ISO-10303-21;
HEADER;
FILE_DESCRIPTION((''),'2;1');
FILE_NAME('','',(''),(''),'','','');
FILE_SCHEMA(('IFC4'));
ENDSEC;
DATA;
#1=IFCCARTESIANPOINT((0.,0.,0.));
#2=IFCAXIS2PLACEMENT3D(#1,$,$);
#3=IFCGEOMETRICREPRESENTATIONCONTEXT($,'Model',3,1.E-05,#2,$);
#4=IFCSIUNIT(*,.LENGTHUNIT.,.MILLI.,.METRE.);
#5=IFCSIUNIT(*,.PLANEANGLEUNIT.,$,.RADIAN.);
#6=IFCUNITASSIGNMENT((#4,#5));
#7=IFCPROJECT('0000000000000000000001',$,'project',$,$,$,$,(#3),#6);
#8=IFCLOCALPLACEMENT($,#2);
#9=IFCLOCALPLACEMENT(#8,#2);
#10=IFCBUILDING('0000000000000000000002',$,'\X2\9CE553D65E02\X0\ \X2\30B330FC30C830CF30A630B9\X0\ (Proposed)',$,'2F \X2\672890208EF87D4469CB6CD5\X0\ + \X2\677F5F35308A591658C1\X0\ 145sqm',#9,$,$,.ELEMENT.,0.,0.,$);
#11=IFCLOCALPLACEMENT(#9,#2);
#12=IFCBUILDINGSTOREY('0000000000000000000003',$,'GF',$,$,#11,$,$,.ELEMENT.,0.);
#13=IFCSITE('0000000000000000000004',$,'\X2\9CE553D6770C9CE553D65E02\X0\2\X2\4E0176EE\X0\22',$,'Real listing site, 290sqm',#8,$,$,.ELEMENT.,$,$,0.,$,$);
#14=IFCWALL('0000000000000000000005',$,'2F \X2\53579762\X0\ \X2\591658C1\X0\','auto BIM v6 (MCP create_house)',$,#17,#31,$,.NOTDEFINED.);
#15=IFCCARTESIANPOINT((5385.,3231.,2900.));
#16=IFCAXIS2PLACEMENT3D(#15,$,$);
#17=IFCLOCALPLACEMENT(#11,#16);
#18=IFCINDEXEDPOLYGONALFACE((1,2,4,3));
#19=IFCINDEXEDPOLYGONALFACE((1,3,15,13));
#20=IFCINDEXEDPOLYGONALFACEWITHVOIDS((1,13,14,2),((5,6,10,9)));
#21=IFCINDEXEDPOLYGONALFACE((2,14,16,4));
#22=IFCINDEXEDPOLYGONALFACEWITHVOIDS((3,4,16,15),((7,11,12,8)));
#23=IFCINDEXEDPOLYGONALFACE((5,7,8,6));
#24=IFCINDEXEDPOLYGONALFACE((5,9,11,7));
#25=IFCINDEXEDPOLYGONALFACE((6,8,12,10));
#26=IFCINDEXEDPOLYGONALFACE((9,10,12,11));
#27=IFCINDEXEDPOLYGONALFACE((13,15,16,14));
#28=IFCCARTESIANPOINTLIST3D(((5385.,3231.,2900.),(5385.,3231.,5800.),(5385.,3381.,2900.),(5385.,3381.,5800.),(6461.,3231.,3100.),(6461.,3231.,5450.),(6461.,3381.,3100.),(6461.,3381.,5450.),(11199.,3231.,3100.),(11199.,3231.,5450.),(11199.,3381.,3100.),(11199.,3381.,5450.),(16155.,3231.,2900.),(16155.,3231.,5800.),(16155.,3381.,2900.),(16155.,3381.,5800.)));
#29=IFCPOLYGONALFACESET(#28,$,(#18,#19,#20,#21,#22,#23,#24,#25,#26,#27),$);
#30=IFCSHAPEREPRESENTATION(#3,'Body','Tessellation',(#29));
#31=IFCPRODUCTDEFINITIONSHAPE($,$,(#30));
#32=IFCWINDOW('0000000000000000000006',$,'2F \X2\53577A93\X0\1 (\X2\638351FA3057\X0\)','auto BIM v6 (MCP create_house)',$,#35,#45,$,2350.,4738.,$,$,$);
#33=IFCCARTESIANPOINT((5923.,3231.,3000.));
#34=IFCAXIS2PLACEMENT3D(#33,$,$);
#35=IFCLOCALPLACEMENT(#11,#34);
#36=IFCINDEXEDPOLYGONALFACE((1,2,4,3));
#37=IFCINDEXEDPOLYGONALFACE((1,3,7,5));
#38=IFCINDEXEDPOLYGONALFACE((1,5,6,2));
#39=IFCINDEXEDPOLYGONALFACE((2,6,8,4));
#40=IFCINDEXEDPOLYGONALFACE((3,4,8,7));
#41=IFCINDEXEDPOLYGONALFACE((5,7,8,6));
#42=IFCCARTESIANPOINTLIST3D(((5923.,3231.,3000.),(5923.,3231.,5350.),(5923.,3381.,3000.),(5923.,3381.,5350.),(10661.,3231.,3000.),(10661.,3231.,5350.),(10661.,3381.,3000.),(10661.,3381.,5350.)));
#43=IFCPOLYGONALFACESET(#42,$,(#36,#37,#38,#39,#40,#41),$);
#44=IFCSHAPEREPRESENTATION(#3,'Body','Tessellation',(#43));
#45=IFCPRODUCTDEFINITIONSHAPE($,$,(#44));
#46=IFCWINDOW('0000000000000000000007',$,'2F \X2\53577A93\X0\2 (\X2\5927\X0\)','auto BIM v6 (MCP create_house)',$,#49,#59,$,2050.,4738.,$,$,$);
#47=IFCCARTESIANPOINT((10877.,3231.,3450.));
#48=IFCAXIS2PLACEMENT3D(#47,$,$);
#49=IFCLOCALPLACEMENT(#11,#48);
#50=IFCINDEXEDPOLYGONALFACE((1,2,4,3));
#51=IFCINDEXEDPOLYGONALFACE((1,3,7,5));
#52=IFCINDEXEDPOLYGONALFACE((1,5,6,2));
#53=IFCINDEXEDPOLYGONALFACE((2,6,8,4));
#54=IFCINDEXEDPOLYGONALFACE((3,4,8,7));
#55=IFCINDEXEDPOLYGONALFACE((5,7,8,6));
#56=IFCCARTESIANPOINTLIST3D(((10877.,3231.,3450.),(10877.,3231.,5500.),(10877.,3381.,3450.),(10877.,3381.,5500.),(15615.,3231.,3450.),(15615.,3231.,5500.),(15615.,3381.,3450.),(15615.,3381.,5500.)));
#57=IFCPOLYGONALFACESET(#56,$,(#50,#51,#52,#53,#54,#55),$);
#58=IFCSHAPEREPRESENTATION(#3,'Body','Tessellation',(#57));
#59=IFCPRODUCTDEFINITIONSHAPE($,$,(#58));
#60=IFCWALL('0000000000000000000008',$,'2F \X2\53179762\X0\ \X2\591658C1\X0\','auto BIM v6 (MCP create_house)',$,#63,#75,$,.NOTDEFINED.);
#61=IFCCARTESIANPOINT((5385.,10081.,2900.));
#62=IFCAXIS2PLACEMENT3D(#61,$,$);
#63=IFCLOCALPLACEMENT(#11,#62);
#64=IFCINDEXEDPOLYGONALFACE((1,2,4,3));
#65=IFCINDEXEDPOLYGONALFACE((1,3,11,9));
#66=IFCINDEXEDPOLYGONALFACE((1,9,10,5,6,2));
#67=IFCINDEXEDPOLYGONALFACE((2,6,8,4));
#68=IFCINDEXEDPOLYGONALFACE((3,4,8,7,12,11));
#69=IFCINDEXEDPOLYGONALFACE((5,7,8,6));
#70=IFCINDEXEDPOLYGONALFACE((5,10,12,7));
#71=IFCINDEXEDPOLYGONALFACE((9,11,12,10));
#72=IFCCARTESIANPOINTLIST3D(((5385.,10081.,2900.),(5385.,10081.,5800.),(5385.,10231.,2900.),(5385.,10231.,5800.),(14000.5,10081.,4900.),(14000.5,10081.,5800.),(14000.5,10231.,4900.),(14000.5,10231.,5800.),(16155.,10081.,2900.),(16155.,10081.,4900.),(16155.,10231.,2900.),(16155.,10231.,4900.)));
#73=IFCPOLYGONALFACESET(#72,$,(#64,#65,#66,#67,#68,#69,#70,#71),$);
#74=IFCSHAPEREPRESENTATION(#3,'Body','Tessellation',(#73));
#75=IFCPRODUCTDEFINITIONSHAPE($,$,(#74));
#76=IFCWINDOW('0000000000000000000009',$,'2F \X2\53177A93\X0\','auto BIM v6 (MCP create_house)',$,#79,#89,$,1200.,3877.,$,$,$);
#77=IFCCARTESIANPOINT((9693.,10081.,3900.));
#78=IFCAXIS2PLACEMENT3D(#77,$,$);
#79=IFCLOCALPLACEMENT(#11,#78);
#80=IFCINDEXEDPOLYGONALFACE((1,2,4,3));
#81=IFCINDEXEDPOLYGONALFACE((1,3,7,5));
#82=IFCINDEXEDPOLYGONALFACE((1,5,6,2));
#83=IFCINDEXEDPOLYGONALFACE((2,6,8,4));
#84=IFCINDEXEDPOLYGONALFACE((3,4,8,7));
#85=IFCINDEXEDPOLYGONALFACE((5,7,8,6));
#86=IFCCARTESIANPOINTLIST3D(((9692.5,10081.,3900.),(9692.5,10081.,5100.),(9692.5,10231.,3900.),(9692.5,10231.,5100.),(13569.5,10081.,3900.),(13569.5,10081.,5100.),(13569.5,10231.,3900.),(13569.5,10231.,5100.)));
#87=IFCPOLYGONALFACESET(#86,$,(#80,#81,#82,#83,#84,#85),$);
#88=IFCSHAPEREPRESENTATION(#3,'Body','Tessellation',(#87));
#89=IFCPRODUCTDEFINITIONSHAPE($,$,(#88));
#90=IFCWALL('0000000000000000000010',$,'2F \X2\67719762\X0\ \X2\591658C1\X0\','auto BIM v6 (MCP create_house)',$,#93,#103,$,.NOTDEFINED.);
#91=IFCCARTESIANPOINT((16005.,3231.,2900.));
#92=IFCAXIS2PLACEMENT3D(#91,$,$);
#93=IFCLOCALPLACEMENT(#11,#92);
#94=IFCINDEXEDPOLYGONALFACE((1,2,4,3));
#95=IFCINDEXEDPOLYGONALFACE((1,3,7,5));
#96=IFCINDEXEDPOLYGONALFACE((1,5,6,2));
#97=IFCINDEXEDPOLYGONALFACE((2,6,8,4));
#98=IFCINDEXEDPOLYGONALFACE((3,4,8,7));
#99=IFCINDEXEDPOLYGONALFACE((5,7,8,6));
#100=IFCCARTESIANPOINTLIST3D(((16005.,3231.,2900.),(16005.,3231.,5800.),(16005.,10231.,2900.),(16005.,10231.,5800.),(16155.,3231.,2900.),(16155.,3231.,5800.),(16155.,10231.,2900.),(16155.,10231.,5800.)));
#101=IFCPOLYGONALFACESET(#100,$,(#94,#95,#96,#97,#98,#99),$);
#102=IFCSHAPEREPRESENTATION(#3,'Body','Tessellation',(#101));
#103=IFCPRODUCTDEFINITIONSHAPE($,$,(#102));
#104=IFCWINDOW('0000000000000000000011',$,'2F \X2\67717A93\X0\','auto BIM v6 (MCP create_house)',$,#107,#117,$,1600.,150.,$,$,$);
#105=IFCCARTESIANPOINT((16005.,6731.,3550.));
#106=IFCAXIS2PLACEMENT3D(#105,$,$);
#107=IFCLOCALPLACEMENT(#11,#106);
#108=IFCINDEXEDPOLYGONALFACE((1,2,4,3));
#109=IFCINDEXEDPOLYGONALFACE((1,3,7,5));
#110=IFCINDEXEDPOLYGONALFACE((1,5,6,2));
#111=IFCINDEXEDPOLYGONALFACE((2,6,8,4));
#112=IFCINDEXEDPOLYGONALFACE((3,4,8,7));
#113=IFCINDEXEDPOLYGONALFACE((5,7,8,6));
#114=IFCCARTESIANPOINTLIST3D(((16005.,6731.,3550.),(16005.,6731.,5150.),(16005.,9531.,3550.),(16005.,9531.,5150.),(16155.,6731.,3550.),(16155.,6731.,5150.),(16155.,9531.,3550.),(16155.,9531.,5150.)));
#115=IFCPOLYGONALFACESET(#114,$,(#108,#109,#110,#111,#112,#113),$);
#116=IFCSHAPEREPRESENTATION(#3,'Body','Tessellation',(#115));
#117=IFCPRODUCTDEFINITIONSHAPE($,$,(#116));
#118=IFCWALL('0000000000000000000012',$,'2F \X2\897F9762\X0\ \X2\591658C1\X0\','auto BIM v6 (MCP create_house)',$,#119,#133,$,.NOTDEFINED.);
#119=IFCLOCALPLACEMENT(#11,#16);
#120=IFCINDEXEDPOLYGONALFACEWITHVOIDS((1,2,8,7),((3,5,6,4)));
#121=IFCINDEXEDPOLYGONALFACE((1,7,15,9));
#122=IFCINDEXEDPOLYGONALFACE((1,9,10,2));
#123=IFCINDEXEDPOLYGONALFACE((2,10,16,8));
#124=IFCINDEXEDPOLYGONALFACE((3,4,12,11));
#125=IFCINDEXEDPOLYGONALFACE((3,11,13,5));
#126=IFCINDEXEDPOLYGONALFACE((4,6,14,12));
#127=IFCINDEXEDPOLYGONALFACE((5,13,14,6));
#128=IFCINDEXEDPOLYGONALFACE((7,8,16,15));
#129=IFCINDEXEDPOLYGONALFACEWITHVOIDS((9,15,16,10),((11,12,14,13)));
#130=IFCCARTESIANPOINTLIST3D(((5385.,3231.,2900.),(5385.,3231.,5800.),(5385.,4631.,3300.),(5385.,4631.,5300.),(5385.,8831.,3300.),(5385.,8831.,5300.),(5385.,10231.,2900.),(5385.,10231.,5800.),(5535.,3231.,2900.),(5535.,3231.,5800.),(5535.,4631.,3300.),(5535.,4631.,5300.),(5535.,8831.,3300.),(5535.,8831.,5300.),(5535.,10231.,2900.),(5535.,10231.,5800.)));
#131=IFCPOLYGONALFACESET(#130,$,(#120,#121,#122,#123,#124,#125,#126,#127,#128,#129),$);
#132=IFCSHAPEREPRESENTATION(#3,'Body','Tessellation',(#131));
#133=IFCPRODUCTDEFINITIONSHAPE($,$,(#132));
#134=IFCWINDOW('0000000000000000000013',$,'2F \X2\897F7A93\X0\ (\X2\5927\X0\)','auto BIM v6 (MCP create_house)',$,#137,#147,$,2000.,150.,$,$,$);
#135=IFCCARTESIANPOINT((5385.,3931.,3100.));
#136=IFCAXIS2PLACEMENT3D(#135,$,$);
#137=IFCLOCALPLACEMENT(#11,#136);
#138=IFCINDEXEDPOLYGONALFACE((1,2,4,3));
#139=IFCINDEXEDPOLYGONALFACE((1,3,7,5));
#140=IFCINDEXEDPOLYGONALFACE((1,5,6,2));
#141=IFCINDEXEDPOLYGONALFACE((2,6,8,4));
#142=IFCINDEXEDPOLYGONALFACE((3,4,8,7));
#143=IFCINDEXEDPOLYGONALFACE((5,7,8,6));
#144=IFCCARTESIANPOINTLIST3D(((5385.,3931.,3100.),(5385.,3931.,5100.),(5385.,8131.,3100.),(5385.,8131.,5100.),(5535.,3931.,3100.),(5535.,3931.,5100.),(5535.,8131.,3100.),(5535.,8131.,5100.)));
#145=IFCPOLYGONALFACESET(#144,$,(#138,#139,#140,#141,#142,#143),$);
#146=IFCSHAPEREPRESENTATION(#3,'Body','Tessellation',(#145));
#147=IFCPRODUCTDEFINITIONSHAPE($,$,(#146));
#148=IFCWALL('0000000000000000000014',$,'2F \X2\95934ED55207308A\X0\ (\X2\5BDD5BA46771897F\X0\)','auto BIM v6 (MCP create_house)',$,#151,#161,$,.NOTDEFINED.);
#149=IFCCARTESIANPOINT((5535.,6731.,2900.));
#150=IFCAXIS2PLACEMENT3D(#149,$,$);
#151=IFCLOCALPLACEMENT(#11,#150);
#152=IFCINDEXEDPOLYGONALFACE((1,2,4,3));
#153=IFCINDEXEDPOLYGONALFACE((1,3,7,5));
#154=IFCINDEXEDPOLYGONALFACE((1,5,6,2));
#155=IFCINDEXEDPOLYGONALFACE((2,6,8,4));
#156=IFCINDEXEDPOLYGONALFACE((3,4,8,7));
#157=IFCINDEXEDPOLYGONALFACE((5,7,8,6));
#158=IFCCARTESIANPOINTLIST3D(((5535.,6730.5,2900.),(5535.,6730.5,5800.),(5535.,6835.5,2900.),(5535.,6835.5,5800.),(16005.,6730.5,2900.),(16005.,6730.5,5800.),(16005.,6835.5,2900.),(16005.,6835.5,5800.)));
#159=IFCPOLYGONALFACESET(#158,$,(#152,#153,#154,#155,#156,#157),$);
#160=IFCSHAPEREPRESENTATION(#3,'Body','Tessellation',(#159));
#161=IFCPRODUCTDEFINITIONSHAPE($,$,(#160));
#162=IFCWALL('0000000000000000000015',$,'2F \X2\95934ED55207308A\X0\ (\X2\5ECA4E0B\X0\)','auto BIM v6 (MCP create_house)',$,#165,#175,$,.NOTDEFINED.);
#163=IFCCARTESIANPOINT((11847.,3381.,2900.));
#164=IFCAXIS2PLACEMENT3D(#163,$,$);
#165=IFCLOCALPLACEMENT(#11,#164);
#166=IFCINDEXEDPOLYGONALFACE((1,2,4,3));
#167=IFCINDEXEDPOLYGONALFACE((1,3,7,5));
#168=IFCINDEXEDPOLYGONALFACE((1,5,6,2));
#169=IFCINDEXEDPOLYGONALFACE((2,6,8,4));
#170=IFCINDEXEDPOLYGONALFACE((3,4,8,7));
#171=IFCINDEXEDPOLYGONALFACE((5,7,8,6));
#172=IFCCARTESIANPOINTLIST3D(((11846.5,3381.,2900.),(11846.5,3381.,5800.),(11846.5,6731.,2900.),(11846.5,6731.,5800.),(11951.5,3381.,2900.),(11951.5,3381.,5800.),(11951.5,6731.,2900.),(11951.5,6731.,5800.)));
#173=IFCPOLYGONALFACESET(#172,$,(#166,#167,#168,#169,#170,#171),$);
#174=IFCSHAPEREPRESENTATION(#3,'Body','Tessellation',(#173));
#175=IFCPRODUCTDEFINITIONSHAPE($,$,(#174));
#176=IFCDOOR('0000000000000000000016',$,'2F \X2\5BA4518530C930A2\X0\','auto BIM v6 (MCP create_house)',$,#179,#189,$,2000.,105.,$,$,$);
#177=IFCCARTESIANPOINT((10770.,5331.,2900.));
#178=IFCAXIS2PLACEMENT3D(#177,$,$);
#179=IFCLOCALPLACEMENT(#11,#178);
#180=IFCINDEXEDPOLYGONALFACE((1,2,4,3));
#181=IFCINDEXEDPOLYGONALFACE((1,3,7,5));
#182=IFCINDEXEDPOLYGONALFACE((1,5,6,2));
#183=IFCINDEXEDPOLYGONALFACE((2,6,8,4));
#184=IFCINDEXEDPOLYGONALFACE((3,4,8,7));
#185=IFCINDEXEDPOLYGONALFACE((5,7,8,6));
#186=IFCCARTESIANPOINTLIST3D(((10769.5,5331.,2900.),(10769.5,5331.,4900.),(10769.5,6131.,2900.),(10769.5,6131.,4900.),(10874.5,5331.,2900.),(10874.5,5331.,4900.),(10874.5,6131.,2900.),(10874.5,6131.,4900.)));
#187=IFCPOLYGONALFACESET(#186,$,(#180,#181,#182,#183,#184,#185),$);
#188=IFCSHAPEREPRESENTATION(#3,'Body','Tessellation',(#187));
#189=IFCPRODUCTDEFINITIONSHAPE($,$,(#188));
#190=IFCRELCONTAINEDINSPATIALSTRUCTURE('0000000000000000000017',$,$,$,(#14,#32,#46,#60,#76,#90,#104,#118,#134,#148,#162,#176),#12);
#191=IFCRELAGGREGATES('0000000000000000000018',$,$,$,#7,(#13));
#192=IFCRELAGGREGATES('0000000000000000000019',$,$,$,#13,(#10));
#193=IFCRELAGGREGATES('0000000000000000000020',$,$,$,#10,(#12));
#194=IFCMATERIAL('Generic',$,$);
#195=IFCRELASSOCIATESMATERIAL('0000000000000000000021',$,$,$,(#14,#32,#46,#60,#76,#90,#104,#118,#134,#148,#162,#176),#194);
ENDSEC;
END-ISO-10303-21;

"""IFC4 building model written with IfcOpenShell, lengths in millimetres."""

from ifc_helpers import new_model, si_unit, frame, frame_2d, origin, place, context, project, spatial, rectangle, extrude, material, element, fill, save


model = new_model("IFC4")

# Units and contexts
model_context = context("Model", 3, precision=1e-05, world=origin())
ifc_project = project(units=[si_unit("LENGTHUNIT", "METRE", prefix="MILLI"), si_unit("PLANEANGLEUNIT", "RADIAN")], contexts=[model_context])

# Site, building, storey
site_placement = place(None, origin())
site = spatial("IfcSite", under=ifc_project, at=site_placement, Name="鳥取県鳥取市2丁目22", ObjectType="Real listing site, 290sqm", CompositionType="ELEMENT", RefElevation=0.0)
building_placement = place(site_placement, origin())
building = spatial("IfcBuilding", under=site, at=building_placement, Name="鳥取市 コートハウス (Proposed)", ObjectType="2F 木造軸組構法 + 板張り外壁 145sqm", CompositionType="ELEMENT", ElevationOfRefHeight=0.0, ElevationOfTerrain=0.0)
storey_placement = place(building_placement, origin())
storey = spatial("IfcBuildingStorey", under=building, at=storey_placement, Name="GF", CompositionType="ELEMENT", Elevation=0.0)

# Shared definitions
ifc_material = material(Name="Generic")

# Wall, openings, windows
wall_1_placement = place(storey_placement, frame((5385.0, 3231.0, 2900.0)))
wall_1 = element("IfcWall", 1, at=wall_1_placement, inside=storey, material=ifc_material, Name="2F 南面 外壁", Description="auto BIM v6 (MCP create_house)", PredefinedType="NOTDEFINED", context=model_context, shape_type="SweptSolid", body=[
    extrude(rectangle(XDim=10770.0, YDim=150.0, at=frame_2d((5385.0, 75.0))), frame((5385.0, 3231.0, 2900.0)), (0.0, 0.0, 1.0), 2900.0),
])
opening_1_placement = place(storey_placement, frame((5923.0, 3231.0, 3000.0)))
opening_1 = element("IfcOpeningElement", 2, at=opening_1_placement, cuts=wall_1, PredefinedType="NOTDEFINED", context=model_context, shape_type="SweptSolid", body=[
    extrude(rectangle(XDim=4738.0, YDim=150.0, at=frame_2d((2369.0, 75.0))), frame((5923.0, 3231.0, 3000.0)), (0.0, 0.0, 1.0), 2350.0),
])
opening_2_placement = place(storey_placement, frame((10877.0, 3231.0, 3450.0)))
opening_2 = element("IfcOpeningElement", 3, at=opening_2_placement, cuts=wall_1, PredefinedType="NOTDEFINED", context=model_context, shape_type="SweptSolid", body=[
    extrude(rectangle(XDim=4738.0, YDim=150.0, at=frame_2d((2369.0, 75.0))), frame((10877.0, 3231.0, 3450.0)), (0.0, 0.0, 1.0), 2050.0),
])
window_1_placement = place(storey_placement, frame((5923.0, 3231.0, 3000.0)))
window_1 = element("IfcWindow", 4, at=window_1_placement, inside=storey, material=ifc_material, Name="2F 南窓1 (掃出し)", Description="auto BIM v6 (MCP create_house)", OverallHeight=2350.0, OverallWidth=4738.0, context=model_context, shape_type="SweptSolid", body=[
    extrude(rectangle(XDim=4738.0, YDim=150.0, at=frame_2d((2369.0, 75.0))), frame((5923.0, 3231.0, 3000.0)), (0.0, 0.0, 1.0), 2350.0),
])
fill(opening_1, window_1)
window_2_placement = place(storey_placement, frame((10877.0, 3231.0, 3450.0)))
window_2 = element("IfcWindow", 5, at=window_2_placement, inside=storey, material=ifc_material, Name="2F 南窓2 (大)", Description="auto BIM v6 (MCP create_house)", OverallHeight=2050.0, OverallWidth=4738.0, context=model_context, shape_type="SweptSolid", body=[
    extrude(rectangle(XDim=4738.0, YDim=150.0, at=frame_2d((2369.0, 75.0))), frame((10877.0, 3231.0, 3450.0)), (0.0, 0.0, 1.0), 2050.0),
])
fill(opening_2, window_2)

# Walls, openings, windows
wall_2_placement = place(storey_placement, frame((5385.0, 10081.0, 2900.0)))
wall_2 = element("IfcWall", 6, at=wall_2_placement, inside=storey, material=ifc_material, Name="2F 北面 外壁", Description="auto BIM v6 (MCP create_house)", PredefinedType="NOTDEFINED", context=model_context, shape_type="SweptSolid", body=[
    extrude(rectangle(XDim=10770.0, YDim=150.0, at=frame_2d((5385.0, 75.0))), frame((5385.0, 10081.0, 2900.0)), (0.0, 0.0, 1.0), 2900.0),
])
opening_3_placement = place(storey_placement, frame((9693.0, 10081.0, 3900.0)))
opening_3 = element("IfcOpeningElement", 7, at=opening_3_placement, cuts=wall_2, PredefinedType="NOTDEFINED", context=model_context, shape_type="SweptSolid", body=[
    extrude(rectangle(XDim=3877.0, YDim=150.0, at=frame_2d((1938.0, 75.0))), frame((9693.0, 10081.0, 3900.0)), (0.0, 0.0, 1.0), 1200.0),
])
window_3_placement = place(storey_placement, frame((9693.0, 10081.0, 3900.0)))
window_3 = element("IfcWindow", 8, at=window_3_placement, inside=storey, material=ifc_material, Name="2F 北窓", Description="auto BIM v6 (MCP create_house)", OverallHeight=1200.0, OverallWidth=3877.0, context=model_context, shape_type="SweptSolid", body=[
    extrude(rectangle(XDim=3877.0, YDim=150.0, at=frame_2d((1938.0, 75.0))), frame((9693.0, 10081.0, 3900.0)), (0.0, 0.0, 1.0), 1200.0),
])
fill(opening_3, window_3)
wall_3_placement = place(storey_placement, frame((16005.0, 3231.0, 2900.0)))
wall_3 = element("IfcWall", 9, at=wall_3_placement, inside=storey, material=ifc_material, Name="2F 東面 外壁", Description="auto BIM v6 (MCP create_house)", PredefinedType="NOTDEFINED", context=model_context, shape_type="SweptSolid", body=[
    extrude(rectangle(XDim=150.0, YDim=7000.0, at=frame_2d((75.0, 3500.0))), frame((16005.0, 3231.0, 2900.0)), (0.0, 0.0, 1.0), 2900.0),
])
opening_4_placement = place(storey_placement, frame((16005.0, 6731.0, 3550.0)))
opening_4 = element("IfcOpeningElement", 10, at=opening_4_placement, cuts=wall_3, PredefinedType="NOTDEFINED", context=model_context, shape_type="SweptSolid", body=[
    extrude(rectangle(XDim=150.0, YDim=2800.0, at=frame_2d((75.0, 1400.0))), frame((16005.0, 6731.0, 3550.0)), (0.0, 0.0, 1.0), 1600.0),
])
window_4_placement = place(storey_placement, frame((16005.0, 6731.0, 3550.0)))
window_4 = element("IfcWindow", 11, at=window_4_placement, inside=storey, material=ifc_material, Name="2F 東窓", Description="auto BIM v6 (MCP create_house)", OverallHeight=1600.0, OverallWidth=150.0, context=model_context, shape_type="SweptSolid", body=[
    extrude(rectangle(XDim=150.0, YDim=2800.0, at=frame_2d((75.0, 1400.0))), frame((16005.0, 6731.0, 3550.0)), (0.0, 0.0, 1.0), 1600.0),
])
fill(opening_4, window_4)
wall_4_placement = place(storey_placement, frame((5385.0, 3231.0, 2900.0)))
wall_4 = element("IfcWall", 12, at=wall_4_placement, inside=storey, material=ifc_material, Name="2F 西面 外壁", Description="auto BIM v6 (MCP create_house)", PredefinedType="NOTDEFINED", context=model_context, shape_type="SweptSolid", body=[
    extrude(rectangle(XDim=150.0, YDim=7000.0, at=frame_2d((75.0, 3500.0))), frame((5385.0, 3231.0, 2900.0)), (0.0, 0.0, 1.0), 2900.0),
])
opening_5_placement = place(storey_placement, frame((5385.0, 3931.0, 3100.0)))
opening_5 = element("IfcOpeningElement", 13, at=opening_5_placement, cuts=wall_4, PredefinedType="NOTDEFINED", context=model_context, shape_type="SweptSolid", body=[
    extrude(rectangle(XDim=150.0, YDim=4200.0, at=frame_2d((75.0, 2100.0))), frame((5385.0, 3931.0, 3100.0)), (0.0, 0.0, 1.0), 2000.0),
])
window_5_placement = place(storey_placement, frame((5385.0, 3931.0, 3100.0)))
window_5 = element("IfcWindow", 14, at=window_5_placement, inside=storey, material=ifc_material, Name="2F 西窓 (大)", Description="auto BIM v6 (MCP create_house)", OverallHeight=2000.0, OverallWidth=150.0, context=model_context, shape_type="SweptSolid", body=[
    extrude(rectangle(XDim=150.0, YDim=4200.0, at=frame_2d((75.0, 2100.0))), frame((5385.0, 3931.0, 3100.0)), (0.0, 0.0, 1.0), 2000.0),
])
fill(opening_5, window_5)

# Walls
wall_5_placement = place(storey_placement, frame((5535.0, 6731.0, 2900.0)))
element("IfcWall", 15, at=wall_5_placement, inside=storey, material=ifc_material, Name="2F 間仕切り (寝室東西)", Description="auto BIM v6 (MCP create_house)", PredefinedType="NOTDEFINED", context=model_context, shape_type="SweptSolid", body=[
    extrude(rectangle(XDim=10470.0, YDim=105.0, at=frame_2d((5235.0, 52.0))), frame((5535.0, 6731.0, 2900.0)), (0.0, 0.0, 1.0), 2900.0),
])
wall_6_placement = place(storey_placement, frame((11847.0, 3381.0, 2900.0)))
element("IfcWall", 16, at=wall_6_placement, inside=storey, material=ifc_material, Name="2F 間仕切り (廊下)", Description="auto BIM v6 (MCP create_house)", PredefinedType="NOTDEFINED", context=model_context, shape_type="SweptSolid", body=[
    extrude(rectangle(XDim=105.0, YDim=3350.0, at=frame_2d((52.0, 1675.0))), frame((11847.0, 3381.0, 2900.0)), (0.0, 0.0, 1.0), 2900.0),
])

# Door
door_1_placement = place(storey_placement, frame((10770.0, 5331.0, 2900.0)))
element("IfcDoor", 17, at=door_1_placement, inside=storey, material=ifc_material, Name="2F 室内ドア", Description="auto BIM v6 (MCP create_house)", OverallHeight=2000.0, OverallWidth=105.0, context=model_context, shape_type="SweptSolid", body=[
    extrude(rectangle(XDim=105.0, YDim=800.0, at=frame_2d((52.0, 400.0))), frame((10770.0, 5331.0, 2900.0)), (0.0, 0.0, 1.0), 2000.0),
])

save(model, "model.ifc")
